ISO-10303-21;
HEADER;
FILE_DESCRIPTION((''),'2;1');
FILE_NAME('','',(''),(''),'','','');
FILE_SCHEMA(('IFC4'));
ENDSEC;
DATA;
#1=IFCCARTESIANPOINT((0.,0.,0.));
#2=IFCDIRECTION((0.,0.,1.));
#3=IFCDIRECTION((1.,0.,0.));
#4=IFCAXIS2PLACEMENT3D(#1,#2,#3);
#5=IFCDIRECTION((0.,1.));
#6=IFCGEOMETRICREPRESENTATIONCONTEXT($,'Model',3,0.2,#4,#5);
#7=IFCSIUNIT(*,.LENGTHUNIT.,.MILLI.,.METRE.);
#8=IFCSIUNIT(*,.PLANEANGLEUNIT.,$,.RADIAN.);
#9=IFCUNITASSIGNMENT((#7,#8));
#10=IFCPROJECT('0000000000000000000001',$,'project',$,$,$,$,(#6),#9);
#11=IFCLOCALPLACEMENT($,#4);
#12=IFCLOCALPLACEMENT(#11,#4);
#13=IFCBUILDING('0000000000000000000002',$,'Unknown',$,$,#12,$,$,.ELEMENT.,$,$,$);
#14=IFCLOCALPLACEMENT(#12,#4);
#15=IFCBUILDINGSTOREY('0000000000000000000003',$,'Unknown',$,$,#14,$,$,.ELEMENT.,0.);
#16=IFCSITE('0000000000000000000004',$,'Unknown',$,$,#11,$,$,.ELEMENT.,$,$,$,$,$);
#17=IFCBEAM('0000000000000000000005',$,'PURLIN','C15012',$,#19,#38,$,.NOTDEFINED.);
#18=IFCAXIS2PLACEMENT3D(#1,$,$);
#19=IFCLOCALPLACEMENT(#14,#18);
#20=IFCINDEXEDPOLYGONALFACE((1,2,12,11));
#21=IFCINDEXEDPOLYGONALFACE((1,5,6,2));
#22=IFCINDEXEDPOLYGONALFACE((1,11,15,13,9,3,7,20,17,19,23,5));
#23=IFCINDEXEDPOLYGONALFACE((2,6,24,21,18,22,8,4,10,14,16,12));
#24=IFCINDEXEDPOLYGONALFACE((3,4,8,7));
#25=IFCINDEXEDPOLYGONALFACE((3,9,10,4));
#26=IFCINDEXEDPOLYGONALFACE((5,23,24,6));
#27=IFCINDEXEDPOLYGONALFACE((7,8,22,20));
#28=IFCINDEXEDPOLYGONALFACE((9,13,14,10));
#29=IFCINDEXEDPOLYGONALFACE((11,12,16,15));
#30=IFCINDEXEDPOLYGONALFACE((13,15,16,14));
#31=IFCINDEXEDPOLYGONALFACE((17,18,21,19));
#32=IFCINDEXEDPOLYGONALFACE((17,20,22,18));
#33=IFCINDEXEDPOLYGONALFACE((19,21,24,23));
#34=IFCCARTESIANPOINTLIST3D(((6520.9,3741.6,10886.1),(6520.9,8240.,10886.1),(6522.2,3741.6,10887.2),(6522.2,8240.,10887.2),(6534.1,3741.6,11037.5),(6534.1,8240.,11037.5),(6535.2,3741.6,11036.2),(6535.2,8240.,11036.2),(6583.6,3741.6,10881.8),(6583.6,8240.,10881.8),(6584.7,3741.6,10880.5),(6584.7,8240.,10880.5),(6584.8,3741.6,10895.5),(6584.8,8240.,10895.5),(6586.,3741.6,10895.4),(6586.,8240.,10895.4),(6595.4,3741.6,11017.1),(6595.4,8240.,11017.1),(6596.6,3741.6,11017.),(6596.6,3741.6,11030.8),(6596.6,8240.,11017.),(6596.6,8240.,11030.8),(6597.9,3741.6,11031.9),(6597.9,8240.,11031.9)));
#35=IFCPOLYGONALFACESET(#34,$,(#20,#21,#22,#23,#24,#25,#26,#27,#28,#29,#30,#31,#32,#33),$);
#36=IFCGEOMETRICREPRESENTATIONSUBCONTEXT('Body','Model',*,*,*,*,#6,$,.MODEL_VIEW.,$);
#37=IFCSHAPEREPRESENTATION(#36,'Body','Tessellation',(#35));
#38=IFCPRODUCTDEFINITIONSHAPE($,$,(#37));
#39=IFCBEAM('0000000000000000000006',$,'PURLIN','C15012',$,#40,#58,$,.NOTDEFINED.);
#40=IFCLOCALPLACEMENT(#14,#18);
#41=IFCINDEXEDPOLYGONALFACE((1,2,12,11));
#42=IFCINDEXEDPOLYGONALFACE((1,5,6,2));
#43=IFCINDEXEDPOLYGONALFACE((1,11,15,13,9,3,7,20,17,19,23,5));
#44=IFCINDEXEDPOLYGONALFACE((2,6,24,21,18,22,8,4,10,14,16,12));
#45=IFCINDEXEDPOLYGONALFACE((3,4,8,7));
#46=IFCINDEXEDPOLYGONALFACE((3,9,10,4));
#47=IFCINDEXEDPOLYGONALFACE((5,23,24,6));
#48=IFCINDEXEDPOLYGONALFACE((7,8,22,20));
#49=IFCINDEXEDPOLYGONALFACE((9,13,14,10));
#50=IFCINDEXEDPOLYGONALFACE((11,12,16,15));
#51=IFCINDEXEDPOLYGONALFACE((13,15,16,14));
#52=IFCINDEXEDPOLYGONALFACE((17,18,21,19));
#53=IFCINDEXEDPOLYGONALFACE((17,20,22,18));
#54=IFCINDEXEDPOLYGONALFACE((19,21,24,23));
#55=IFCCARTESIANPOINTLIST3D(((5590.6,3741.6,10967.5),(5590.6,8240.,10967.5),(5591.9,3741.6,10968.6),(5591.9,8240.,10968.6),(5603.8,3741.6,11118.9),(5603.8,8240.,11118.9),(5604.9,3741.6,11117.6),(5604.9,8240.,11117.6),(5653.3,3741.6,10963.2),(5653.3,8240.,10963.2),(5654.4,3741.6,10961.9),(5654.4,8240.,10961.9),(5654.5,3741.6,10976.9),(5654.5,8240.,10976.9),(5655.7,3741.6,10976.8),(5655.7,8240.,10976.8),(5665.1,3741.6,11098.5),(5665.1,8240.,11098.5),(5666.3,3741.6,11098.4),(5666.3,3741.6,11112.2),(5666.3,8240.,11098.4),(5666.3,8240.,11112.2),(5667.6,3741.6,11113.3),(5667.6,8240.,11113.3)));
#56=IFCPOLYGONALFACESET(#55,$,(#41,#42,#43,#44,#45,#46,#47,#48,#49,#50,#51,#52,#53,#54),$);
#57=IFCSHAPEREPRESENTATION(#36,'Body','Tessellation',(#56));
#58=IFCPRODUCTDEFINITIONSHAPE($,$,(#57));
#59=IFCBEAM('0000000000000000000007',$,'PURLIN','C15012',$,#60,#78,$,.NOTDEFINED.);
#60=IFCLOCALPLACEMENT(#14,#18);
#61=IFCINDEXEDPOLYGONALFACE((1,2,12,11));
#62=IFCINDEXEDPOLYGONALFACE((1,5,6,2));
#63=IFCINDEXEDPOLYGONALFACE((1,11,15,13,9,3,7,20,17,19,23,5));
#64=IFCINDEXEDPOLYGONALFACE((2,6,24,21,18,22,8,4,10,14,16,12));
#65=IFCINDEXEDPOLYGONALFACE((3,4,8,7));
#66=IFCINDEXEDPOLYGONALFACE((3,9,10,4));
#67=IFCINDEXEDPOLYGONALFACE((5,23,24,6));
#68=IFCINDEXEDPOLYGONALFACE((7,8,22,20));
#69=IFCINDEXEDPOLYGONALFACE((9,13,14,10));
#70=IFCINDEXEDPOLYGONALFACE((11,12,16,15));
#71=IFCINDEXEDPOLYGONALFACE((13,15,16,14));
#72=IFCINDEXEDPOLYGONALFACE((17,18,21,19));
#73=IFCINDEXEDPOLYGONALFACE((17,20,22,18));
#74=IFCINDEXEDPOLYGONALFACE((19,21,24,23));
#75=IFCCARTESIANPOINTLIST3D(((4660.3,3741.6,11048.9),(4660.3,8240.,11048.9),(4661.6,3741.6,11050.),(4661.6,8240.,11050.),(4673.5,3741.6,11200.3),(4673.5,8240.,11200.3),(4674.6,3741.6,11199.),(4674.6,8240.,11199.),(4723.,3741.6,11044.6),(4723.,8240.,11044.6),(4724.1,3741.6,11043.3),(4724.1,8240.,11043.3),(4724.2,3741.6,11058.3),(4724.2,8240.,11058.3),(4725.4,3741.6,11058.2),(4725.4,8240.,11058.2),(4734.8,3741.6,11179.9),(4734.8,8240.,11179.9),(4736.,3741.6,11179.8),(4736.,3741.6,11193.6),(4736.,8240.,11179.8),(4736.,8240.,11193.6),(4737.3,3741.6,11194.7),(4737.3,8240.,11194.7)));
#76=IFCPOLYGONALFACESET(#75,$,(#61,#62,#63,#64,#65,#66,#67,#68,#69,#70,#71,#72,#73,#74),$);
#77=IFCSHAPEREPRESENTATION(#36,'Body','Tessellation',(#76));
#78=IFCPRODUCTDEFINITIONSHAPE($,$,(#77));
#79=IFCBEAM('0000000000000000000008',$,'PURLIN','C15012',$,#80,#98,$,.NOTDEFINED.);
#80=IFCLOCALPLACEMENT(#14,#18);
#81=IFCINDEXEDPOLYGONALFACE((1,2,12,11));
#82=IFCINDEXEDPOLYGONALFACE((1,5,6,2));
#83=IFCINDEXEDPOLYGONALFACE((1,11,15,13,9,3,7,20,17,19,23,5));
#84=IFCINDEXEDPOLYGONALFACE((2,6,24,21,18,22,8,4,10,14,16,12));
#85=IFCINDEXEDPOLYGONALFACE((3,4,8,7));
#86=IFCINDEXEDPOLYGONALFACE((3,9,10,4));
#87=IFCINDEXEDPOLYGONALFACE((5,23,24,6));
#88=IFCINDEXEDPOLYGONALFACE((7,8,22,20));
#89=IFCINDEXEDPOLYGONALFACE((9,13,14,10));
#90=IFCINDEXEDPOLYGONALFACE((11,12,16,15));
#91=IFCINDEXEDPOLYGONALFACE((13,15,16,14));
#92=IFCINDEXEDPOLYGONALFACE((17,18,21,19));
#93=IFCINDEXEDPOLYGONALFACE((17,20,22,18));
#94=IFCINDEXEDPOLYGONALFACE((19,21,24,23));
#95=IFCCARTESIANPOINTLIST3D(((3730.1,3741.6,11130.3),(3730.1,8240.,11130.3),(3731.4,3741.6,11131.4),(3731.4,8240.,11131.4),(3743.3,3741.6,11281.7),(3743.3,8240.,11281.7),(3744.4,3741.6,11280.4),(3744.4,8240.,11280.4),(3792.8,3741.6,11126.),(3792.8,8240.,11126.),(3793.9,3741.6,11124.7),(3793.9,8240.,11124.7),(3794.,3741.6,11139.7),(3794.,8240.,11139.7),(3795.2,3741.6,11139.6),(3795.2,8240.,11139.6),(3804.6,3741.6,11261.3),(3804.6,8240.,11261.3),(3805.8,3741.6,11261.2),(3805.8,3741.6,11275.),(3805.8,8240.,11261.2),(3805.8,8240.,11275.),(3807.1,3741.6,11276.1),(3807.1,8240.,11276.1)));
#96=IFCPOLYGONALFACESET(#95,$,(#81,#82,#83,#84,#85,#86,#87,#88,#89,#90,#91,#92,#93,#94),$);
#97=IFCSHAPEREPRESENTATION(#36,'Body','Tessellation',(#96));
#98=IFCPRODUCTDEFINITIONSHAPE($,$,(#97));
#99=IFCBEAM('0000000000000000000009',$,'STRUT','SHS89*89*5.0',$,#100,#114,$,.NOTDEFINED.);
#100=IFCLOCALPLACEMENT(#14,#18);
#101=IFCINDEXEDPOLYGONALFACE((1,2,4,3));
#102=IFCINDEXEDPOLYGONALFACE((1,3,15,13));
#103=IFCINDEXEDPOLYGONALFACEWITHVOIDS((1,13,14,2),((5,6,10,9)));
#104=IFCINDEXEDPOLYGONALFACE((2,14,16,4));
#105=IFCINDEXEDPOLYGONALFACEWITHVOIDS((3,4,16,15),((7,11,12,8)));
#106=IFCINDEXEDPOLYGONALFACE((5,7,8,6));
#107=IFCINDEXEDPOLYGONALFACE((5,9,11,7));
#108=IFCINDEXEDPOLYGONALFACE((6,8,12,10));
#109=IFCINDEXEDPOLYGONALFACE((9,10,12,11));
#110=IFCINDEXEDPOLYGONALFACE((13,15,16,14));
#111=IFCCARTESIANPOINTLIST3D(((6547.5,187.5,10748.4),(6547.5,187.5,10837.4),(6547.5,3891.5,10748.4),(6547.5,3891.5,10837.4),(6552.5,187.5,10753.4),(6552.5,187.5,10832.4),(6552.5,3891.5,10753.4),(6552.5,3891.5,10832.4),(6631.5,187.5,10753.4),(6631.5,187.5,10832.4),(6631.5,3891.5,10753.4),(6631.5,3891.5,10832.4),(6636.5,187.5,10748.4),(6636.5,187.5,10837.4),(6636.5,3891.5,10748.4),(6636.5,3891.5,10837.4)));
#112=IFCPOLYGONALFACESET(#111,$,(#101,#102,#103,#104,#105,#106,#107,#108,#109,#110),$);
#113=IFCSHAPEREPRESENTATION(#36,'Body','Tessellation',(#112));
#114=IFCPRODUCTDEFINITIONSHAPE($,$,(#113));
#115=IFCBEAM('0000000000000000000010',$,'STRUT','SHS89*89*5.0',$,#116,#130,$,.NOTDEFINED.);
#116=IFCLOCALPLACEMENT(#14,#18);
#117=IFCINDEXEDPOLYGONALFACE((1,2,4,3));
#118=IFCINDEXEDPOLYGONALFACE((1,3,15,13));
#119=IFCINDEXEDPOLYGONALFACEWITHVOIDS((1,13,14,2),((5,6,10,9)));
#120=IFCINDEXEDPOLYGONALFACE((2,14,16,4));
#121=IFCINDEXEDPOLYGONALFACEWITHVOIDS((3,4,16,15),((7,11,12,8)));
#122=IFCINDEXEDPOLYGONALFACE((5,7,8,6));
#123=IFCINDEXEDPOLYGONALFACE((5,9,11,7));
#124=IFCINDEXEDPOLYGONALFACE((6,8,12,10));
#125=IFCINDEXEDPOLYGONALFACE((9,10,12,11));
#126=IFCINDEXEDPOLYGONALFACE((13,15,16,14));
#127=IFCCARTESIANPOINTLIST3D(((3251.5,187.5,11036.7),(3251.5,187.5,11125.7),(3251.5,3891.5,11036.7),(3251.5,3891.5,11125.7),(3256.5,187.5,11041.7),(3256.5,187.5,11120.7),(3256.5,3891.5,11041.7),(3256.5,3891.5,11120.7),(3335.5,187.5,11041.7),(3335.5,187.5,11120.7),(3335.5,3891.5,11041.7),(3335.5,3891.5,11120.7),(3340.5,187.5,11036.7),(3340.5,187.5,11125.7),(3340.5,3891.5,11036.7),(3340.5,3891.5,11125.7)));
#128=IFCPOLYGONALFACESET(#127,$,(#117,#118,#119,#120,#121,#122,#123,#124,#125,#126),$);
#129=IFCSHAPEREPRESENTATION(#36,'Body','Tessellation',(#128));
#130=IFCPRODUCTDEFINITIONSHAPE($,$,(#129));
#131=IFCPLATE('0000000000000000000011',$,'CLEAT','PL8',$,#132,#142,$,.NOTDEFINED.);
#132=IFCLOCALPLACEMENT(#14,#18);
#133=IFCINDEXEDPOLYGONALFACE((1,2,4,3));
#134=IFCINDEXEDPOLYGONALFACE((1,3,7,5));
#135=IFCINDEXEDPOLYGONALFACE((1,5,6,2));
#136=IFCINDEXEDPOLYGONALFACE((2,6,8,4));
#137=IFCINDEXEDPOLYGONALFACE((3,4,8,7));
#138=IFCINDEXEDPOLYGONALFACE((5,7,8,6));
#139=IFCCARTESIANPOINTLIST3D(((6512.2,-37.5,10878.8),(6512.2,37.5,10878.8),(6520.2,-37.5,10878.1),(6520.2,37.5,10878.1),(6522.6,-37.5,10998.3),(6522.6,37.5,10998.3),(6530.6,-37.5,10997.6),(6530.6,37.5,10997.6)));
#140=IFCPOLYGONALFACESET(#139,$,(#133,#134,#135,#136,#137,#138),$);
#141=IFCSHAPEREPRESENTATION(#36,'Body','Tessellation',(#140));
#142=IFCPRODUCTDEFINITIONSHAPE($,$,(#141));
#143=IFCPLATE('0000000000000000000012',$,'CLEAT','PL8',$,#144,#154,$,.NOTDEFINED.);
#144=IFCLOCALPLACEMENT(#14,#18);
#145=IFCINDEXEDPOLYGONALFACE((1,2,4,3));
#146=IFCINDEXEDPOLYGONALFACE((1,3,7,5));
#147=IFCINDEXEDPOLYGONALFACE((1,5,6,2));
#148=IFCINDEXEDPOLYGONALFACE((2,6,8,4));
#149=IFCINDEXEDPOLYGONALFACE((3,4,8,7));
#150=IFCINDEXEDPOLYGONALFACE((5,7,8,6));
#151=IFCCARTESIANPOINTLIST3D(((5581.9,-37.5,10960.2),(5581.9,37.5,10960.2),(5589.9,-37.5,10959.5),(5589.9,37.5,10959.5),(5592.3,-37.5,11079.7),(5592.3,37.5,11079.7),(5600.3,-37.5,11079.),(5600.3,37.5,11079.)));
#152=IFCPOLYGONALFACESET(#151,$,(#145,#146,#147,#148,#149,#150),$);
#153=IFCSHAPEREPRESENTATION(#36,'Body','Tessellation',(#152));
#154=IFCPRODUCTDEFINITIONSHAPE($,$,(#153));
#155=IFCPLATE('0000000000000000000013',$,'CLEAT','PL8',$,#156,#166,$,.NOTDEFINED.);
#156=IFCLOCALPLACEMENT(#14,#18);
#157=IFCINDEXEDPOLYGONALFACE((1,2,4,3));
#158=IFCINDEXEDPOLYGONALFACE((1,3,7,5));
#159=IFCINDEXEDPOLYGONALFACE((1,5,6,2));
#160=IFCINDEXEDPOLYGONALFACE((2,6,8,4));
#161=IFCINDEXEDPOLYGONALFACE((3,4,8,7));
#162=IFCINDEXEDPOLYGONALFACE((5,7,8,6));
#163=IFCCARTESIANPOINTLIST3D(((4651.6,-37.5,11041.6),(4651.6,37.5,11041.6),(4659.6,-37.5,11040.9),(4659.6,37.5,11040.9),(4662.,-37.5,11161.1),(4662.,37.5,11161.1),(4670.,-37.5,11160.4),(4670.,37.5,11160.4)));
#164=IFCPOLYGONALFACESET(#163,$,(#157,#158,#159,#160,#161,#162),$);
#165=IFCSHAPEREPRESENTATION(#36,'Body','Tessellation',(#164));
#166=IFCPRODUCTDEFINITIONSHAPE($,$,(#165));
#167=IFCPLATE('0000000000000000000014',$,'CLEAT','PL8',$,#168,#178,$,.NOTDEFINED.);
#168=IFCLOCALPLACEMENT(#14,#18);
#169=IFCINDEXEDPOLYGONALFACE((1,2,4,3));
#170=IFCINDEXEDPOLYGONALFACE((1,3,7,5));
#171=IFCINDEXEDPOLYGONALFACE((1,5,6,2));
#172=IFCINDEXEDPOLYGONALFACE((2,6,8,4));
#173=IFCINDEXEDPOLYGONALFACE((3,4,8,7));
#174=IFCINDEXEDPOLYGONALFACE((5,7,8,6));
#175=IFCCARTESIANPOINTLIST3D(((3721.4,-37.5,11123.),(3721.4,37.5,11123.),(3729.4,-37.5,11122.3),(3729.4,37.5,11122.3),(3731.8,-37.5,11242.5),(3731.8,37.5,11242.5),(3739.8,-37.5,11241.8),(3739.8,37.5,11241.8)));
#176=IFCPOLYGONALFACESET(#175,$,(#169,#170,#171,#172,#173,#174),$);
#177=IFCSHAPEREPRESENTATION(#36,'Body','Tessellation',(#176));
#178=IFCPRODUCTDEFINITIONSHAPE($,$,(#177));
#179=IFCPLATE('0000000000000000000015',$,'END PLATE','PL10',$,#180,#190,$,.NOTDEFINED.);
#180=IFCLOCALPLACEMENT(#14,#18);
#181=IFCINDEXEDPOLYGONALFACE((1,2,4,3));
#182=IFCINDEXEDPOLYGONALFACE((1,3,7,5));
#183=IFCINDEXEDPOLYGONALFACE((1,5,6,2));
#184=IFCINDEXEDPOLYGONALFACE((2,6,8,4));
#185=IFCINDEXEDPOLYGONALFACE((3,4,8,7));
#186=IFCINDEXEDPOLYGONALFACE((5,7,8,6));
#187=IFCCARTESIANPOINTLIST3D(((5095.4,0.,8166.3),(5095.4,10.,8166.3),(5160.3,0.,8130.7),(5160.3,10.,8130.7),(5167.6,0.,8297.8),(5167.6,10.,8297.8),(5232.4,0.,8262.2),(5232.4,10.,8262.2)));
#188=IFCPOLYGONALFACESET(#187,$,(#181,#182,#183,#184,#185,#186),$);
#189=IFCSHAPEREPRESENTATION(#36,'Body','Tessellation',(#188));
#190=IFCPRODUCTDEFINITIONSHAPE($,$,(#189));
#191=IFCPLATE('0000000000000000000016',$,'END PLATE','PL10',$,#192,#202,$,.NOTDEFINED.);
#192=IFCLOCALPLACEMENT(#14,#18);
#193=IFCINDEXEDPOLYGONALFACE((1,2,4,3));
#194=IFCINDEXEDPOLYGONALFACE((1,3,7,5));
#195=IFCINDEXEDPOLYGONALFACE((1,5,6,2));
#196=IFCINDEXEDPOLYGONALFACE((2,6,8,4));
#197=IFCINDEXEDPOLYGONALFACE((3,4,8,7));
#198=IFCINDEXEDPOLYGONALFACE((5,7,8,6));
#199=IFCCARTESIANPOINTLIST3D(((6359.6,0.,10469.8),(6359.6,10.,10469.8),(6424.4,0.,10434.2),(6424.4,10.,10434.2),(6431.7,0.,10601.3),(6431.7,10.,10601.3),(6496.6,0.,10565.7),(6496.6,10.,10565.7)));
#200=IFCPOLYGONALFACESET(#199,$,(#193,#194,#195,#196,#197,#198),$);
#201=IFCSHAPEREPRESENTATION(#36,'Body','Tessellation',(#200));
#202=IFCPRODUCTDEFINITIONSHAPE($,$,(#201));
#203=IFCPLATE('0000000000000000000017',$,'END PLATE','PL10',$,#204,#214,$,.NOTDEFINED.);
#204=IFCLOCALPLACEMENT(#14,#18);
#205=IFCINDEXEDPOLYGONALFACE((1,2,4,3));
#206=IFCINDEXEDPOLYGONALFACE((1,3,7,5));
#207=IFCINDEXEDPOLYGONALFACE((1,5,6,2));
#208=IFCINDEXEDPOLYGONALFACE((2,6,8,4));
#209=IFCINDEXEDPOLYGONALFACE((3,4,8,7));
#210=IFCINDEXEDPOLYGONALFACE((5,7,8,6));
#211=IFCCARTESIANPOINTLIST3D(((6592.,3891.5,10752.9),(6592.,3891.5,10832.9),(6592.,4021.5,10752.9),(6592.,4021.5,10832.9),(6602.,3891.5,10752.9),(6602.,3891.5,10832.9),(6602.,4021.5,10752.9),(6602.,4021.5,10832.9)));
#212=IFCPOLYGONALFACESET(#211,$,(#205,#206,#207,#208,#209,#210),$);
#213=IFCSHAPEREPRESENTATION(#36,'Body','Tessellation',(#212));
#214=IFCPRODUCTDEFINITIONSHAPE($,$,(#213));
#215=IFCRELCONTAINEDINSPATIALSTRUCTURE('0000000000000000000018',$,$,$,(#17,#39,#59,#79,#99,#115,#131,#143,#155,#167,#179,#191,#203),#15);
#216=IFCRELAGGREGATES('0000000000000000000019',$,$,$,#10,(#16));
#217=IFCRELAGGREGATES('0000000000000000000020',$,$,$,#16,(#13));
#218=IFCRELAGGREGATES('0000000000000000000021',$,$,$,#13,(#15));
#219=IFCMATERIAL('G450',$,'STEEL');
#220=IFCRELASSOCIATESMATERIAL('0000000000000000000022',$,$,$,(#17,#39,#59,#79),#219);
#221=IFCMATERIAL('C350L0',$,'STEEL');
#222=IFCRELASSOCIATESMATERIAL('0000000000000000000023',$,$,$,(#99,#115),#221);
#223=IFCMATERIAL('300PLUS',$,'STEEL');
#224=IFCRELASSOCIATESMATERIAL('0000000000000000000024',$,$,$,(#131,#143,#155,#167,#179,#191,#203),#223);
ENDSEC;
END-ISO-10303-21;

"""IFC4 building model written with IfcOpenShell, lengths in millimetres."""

from ifc_helpers import new_model, si_unit, direction, frame, origin_with_axes, place, context, subcontext, project, spatial, line, indexed_curve, outline, extrude, material, element, save


model = new_model("IFC4")

# Units and contexts
model_context = context("Model", 3, precision=0.2, world=origin_with_axes(), true_north=direction((0.0, 1.0)))
body_context = subcontext(model_context, "Body", "Model", "MODEL_VIEW")
ifc_project = project(units=[si_unit("LENGTHUNIT", "METRE", prefix="MILLI"), si_unit("PLANEANGLEUNIT", "RADIAN")], contexts=[model_context])

# Site, building, storey
site_placement = place(None, origin_with_axes())
site = spatial("IfcSite", under=ifc_project, at=site_placement, Name="Unknown", CompositionType="ELEMENT")
building_placement = place(site_placement, origin_with_axes())
building = spatial("IfcBuilding", under=site, at=building_placement, Name="Unknown", CompositionType="ELEMENT")
storey_placement = place(building_placement, origin_with_axes())
storey = spatial("IfcBuildingStorey", under=building, at=storey_placement, Name="Unknown", CompositionType="ELEMENT", Elevation=0.0)

# Shared definitions
ifc_material_1 = material(Name="C350L0", Category="STEEL")

# Beams
ifc_material_2 = material(Name="G450", Category="STEEL")
for number, where, z_axis, x_axis, name in (
    (1, (6559.4, 3741.6, 10959.0), (0.996195, 0.0, -0.087156), (0.0, 1.0, 0.0), "PURLIN"),
    (2, (5629.1, 3741.6, 11040.4), (0.996195, 0.0, -0.087156), (0.0, 1.0, 0.0), "PURLIN"),
    (3, (4698.8, 3741.6, 11121.8), (0.996195, 0.0, -0.087156), (0.0, 1.0, 0.0), "PURLIN"),
    (4, (3768.6, 3741.6, 11203.2), (0.996195, 0.0, -0.087156), (0.0, 1.0, 0.0), "PURLIN"),
):
    element("IfcBeam", number, at=place(storey_placement, frame(where, z_axis=z_axis, x_axis=x_axis)), inside=storey, material=ifc_material_2, Name=name, Description="C15012", PredefinedType="NOTDEFINED", context=body_context, shape_type="SolidModel", body=[
        extrude(outline(indexed_curve([(32.0, -76.0), (32.0, -61.0), (30.8, -61.0), (30.8, -74.8), (-30.8, -74.8), (-30.8, 74.8), (30.8, 74.8), (30.8, 61.0), (32.0, 61.0), (32.0, 76.0), (-32.0, 76.0), (-32.0, -76.0)], segments=[line(1, 2, 3, 4, 5, 6, 7, 8, 9, 10, 11, 12, 1)])), frame((0.0, 0.0, 0.0), z_axis=(-1.0, 0.0, 0.0), x_axis=(0.0, 0.0, 1.0)), (0.0, 0.0, -1.0), 4498.4),
    ])
for number, where, z_axis, x_axis, name in (
    (5, (6592.0, 187.5, 10792.9), (0.0, 0.0, 1.0), (0.0, 1.0, 0.0), "STRUT"),
    (6, (3296.0, 187.5, 11081.2), (0.0, 0.0, 1.0), (0.0, 1.0, 0.0), "STRUT"),
):
    element("IfcBeam", number, at=place(storey_placement, frame(where, z_axis=z_axis, x_axis=x_axis)), inside=storey, material=ifc_material_1, Name=name, Description="SHS89*89*5.0", PredefinedType="NOTDEFINED", context=body_context, shape_type="SolidModel", body=[
        extrude(outline(indexed_curve([(-44.5, -44.5), (44.5, -44.5), (44.5, 44.5), (-44.5, 44.5)], segments=[line(1, 2, 3, 4, 1)]), holes=[indexed_curve([(-39.5, -39.5), (-39.5, 39.5), (39.5, 39.5), (39.5, -39.5)], segments=[line(1, 2, 3, 4, 1)])]), frame((0.0, 0.0, 0.0), z_axis=(-1.0, 0.0, 0.0), x_axis=(0.0, 0.0, 1.0)), (0.0, 0.0, -1.0), 3704.0),
    ])

# Plates
ifc_material_3 = material(Name="300PLUS", Category="STEEL")
for number, where, z_axis, x_axis, name in (
    (7, (6516.2, 37.5, 10878.4), (-0.996234, 0.0, 0.086702), (0.0, -1.0, 0.0), "CLEAT"),
    (8, (5585.9, 37.5, 10959.8), (-0.996234, 0.0, 0.086702), (0.0, -1.0, 0.0), "CLEAT"),
    (9, (4655.6, 37.5, 11041.2), (-0.996234, 0.0, 0.086702), (0.0, -1.0, 0.0), "CLEAT"),
    (10, (3725.4, 37.5, 11122.6), (-0.996234, 0.0, 0.086702), (0.0, -1.0, 0.0), "CLEAT"),
):
    element("IfcPlate", number, at=place(storey_placement, frame(where, z_axis=z_axis, x_axis=x_axis)), inside=storey, material=ifc_material_3, Name=name, Description="PL8", PredefinedType="NOTDEFINED", context=body_context, shape_type="SolidModel", body=[
        extrude(outline(indexed_curve([(0.0, 0.0), (75.0, 0.0), (75.0, 120.0), (0.0, 120.0)], segments=[line(1, 2, 3, 4, 1)])), frame((0.0, 0.0, 4.0), z_axis=(0.0, 0.0, 1.0), x_axis=(1.0, 0.0, 0.0)), (0.0, 0.0, -1.0), 8.0),
    ])
plate_1_placement = place(storey_placement, frame((5167.6, 5.0, 8297.8), z_axis=(0.0, 1.0, 0.0), x_axis=(0.876444, 0.0, -0.481503)))
element("IfcPlate", 11, at=plate_1_placement, inside=storey, material=ifc_material_3, Name="END PLATE", Description="PL10", PredefinedType="NOTDEFINED", context=body_context, shape_type="SolidModel", body=[
    extrude(outline(indexed_curve([(0.0, 0.0), (73.9, 0.0), (74.1, 150.0), (0.0, 150.0)], segments=[line(1, 2, 3, 4, 1)])), frame((0.0, 0.0, 5.0), z_axis=(0.0, 0.0, 1.0), x_axis=(1.0, 0.0, 0.0)), (0.0, 0.0, -1.0), 10.0),
])
plate_2_placement = place(storey_placement, frame((6431.7, 5.0, 10601.3), z_axis=(0.0, 1.0, 0.0), x_axis=(0.876757, 0.0, -0.480933)))
element("IfcPlate", 12, at=plate_2_placement, inside=storey, material=ifc_material_3, Name="END PLATE", Description="PL10", PredefinedType="NOTDEFINED", context=body_context, shape_type="SolidModel", body=[
    extrude(outline(indexed_curve([(0.0, 0.0), (74.0, 0.0), (74.0, 150.0), (0.0, 150.0)], segments=[line(1, 2, 3, 4, 1)])), frame((0.0, 0.0, 5.0), z_axis=(0.0, 0.0, 1.0), x_axis=(1.0, 0.0, 0.0)), (0.0, 0.0, -1.0), 10.0),
])
plate_3_placement = place(storey_placement, frame((6597.0, 3891.5, 10752.9), z_axis=(1.0, 0.0, 0.0), x_axis=(0.0, 1.0, 0.0)))
element("IfcPlate", 13, at=plate_3_placement, inside=storey, material=ifc_material_3, Name="END PLATE", Description="PL10", PredefinedType="NOTDEFINED", context=body_context, shape_type="SolidModel", body=[
    extrude(outline(indexed_curve([(0.0, 0.0), (130.0, 0.0), (130.0, 80.0), (0.0, 80.0)], segments=[line(1, 2, 3, 4, 1)])), frame((0.0, 0.0, 5.0), z_axis=(0.0, 0.0, 1.0), x_axis=(1.0, 0.0, 0.0)), (0.0, 0.0, -1.0), 10.0),
])

save(model, "model.ifc")
